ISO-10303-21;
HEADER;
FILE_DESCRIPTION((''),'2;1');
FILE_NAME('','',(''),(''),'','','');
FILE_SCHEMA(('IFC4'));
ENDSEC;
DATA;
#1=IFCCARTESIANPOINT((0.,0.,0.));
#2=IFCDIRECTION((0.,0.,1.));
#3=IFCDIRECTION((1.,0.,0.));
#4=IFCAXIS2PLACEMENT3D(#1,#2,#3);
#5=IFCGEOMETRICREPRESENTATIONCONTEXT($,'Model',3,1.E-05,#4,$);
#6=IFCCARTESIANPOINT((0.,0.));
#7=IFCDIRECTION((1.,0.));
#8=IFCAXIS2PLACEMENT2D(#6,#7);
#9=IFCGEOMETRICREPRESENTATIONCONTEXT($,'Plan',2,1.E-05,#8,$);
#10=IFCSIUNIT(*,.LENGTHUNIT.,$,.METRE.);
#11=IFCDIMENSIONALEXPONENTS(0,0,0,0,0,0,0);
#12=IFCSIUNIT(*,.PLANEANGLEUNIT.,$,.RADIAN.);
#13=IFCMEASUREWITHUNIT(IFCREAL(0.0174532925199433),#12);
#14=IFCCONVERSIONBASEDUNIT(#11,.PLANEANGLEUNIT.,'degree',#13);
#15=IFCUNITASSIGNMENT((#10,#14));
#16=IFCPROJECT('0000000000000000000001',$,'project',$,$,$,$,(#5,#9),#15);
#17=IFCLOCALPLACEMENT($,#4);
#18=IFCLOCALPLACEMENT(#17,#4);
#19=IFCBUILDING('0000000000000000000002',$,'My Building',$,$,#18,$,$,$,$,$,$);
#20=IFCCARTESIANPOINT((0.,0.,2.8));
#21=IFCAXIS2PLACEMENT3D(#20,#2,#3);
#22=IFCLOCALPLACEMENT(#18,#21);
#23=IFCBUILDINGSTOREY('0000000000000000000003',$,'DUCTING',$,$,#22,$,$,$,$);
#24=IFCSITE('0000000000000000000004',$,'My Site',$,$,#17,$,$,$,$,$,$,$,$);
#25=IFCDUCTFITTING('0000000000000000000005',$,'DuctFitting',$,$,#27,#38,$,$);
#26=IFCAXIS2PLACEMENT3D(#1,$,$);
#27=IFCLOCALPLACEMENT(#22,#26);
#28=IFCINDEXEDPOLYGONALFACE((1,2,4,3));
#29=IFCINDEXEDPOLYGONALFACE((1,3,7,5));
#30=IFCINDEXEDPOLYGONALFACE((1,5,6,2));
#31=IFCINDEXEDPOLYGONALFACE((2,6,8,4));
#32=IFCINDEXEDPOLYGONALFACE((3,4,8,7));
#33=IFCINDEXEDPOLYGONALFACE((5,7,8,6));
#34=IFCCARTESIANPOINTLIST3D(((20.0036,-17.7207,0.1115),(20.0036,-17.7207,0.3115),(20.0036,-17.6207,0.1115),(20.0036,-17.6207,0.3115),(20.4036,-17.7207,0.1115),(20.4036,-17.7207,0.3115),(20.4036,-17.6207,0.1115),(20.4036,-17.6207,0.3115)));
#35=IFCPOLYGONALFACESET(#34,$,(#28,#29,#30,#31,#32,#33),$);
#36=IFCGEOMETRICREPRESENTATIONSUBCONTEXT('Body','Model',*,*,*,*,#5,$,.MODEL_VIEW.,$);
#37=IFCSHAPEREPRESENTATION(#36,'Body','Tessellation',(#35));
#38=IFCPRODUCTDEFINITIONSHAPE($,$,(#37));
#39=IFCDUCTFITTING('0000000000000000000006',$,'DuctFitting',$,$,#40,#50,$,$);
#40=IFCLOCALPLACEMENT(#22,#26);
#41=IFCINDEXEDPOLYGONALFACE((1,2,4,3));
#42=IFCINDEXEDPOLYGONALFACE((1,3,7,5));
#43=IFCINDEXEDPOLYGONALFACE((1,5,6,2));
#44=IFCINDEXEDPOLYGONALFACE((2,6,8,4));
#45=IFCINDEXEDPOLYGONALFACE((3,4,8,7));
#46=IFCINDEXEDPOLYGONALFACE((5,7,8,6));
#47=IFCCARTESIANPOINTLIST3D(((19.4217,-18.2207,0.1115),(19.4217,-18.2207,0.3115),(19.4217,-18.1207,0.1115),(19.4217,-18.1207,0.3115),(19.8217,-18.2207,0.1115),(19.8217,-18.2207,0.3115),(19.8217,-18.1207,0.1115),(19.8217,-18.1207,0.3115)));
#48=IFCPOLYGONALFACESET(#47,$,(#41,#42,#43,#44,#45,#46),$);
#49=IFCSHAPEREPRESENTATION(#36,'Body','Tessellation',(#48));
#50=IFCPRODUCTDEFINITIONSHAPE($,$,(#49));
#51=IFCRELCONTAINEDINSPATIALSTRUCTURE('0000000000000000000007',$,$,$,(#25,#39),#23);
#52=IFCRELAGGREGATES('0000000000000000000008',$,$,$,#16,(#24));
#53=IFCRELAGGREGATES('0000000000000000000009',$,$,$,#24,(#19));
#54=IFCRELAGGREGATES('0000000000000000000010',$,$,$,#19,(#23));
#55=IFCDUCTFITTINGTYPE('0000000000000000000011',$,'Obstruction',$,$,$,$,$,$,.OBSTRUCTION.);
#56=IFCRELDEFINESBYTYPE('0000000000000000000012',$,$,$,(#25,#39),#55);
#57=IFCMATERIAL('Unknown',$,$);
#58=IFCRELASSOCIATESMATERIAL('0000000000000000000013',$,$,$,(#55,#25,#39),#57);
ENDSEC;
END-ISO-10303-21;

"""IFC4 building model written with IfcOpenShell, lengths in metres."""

from ifc_helpers import new_model, entity, si_unit, converted_unit, frame, origin_with_axes, origin_2d_with_axis, place, context, subcontext, project, spatial, rectangle, extrude, material, material_profile, profile_set, profile_usage, type_object, element, save


model = new_model("IFC4")

# Units and contexts
model_context = context("Model", 3, precision=1e-05, world=origin_with_axes())
plan_context = context("Plan", 2, precision=1e-05, world=origin_2d_with_axis())
body_context = subcontext(model_context, "Body", "Model", "MODEL_VIEW")
ifc_project = project(units=[si_unit("LENGTHUNIT", "METRE"), converted_unit("PLANEANGLEUNIT", "degree", entity("IfcReal", 0.0174532925199433), si_unit("PLANEANGLEUNIT", "RADIAN"), dimensions=[0, 0, 0, 0, 0, 0, 0])], contexts=[model_context, plan_context])

# Site, building, storey
site_placement = place(None, origin_with_axes())
site = spatial("IfcSite", under=ifc_project, at=site_placement, Name="My Site")
building_placement = place(site_placement, origin_with_axes())
building = spatial("IfcBuilding", under=site, at=building_placement, Name="My Building")
storey_placement = place(building_placement, frame((0.0, 0.0, 2.8), z_axis=(0.0, 0.0, 1.0), x_axis=(1.0, 0.0, 0.0)))
storey = spatial("IfcBuildingStorey", under=building, at=storey_placement, Name="DUCTING")

# Shared definitions
ifc_material = material(Name="Unknown")

# Duct fittings
ifc_material_profile_1 = material_profile(ifc_material, rectangle(XDim=0.4, YDim=0.2))
ifc_profile_set_1 = profile_set([ifc_material_profile_1])
duct_fitting_type_1 = type_object("IfcDuctFittingType", Name="Obstruction", PredefinedType="OBSTRUCTION", material=ifc_profile_set_1)
ifc_profile_usage_1 = profile_usage(ifc_profile_set_1, cardinal=5)
duct_fitting_1_placement = place(storey_placement, frame((20.2036, -17.7207, 0.2115), z_axis=(0.000018, 1.0, 0.000001), x_axis=(-1.0, 0.000018, 0.0)))
element("IfcDuctFitting", 1, at=duct_fitting_1_placement, inside=storey, type_object=duct_fitting_type_1, material=ifc_profile_usage_1, Name="DuctFitting", context=body_context, shape_type="SweptSolid", body=[
    extrude(rectangle(XDim=0.4, YDim=0.2), origin_with_axes(), (0.0, 0.0, 1.0), 0.1),
])
ifc_profile_usage_2 = profile_usage(ifc_profile_set_1, cardinal=5)
duct_fitting_2_placement = place(storey_placement, frame((19.6217, -18.1207, 0.2115), z_axis=(-0.000018, -1.0, 0.000001), x_axis=(1.0, -0.000018, 0.0)))
element("IfcDuctFitting", 2, at=duct_fitting_2_placement, inside=storey, type_object=duct_fitting_type_1, material=ifc_profile_usage_2, Name="DuctFitting", context=body_context, shape_type="SweptSolid", body=[
    extrude(rectangle(XDim=0.4, YDim=0.2), origin_with_axes(), (0.0, 0.0, 1.0), 0.1),
])

save(model, "model.ifc")
